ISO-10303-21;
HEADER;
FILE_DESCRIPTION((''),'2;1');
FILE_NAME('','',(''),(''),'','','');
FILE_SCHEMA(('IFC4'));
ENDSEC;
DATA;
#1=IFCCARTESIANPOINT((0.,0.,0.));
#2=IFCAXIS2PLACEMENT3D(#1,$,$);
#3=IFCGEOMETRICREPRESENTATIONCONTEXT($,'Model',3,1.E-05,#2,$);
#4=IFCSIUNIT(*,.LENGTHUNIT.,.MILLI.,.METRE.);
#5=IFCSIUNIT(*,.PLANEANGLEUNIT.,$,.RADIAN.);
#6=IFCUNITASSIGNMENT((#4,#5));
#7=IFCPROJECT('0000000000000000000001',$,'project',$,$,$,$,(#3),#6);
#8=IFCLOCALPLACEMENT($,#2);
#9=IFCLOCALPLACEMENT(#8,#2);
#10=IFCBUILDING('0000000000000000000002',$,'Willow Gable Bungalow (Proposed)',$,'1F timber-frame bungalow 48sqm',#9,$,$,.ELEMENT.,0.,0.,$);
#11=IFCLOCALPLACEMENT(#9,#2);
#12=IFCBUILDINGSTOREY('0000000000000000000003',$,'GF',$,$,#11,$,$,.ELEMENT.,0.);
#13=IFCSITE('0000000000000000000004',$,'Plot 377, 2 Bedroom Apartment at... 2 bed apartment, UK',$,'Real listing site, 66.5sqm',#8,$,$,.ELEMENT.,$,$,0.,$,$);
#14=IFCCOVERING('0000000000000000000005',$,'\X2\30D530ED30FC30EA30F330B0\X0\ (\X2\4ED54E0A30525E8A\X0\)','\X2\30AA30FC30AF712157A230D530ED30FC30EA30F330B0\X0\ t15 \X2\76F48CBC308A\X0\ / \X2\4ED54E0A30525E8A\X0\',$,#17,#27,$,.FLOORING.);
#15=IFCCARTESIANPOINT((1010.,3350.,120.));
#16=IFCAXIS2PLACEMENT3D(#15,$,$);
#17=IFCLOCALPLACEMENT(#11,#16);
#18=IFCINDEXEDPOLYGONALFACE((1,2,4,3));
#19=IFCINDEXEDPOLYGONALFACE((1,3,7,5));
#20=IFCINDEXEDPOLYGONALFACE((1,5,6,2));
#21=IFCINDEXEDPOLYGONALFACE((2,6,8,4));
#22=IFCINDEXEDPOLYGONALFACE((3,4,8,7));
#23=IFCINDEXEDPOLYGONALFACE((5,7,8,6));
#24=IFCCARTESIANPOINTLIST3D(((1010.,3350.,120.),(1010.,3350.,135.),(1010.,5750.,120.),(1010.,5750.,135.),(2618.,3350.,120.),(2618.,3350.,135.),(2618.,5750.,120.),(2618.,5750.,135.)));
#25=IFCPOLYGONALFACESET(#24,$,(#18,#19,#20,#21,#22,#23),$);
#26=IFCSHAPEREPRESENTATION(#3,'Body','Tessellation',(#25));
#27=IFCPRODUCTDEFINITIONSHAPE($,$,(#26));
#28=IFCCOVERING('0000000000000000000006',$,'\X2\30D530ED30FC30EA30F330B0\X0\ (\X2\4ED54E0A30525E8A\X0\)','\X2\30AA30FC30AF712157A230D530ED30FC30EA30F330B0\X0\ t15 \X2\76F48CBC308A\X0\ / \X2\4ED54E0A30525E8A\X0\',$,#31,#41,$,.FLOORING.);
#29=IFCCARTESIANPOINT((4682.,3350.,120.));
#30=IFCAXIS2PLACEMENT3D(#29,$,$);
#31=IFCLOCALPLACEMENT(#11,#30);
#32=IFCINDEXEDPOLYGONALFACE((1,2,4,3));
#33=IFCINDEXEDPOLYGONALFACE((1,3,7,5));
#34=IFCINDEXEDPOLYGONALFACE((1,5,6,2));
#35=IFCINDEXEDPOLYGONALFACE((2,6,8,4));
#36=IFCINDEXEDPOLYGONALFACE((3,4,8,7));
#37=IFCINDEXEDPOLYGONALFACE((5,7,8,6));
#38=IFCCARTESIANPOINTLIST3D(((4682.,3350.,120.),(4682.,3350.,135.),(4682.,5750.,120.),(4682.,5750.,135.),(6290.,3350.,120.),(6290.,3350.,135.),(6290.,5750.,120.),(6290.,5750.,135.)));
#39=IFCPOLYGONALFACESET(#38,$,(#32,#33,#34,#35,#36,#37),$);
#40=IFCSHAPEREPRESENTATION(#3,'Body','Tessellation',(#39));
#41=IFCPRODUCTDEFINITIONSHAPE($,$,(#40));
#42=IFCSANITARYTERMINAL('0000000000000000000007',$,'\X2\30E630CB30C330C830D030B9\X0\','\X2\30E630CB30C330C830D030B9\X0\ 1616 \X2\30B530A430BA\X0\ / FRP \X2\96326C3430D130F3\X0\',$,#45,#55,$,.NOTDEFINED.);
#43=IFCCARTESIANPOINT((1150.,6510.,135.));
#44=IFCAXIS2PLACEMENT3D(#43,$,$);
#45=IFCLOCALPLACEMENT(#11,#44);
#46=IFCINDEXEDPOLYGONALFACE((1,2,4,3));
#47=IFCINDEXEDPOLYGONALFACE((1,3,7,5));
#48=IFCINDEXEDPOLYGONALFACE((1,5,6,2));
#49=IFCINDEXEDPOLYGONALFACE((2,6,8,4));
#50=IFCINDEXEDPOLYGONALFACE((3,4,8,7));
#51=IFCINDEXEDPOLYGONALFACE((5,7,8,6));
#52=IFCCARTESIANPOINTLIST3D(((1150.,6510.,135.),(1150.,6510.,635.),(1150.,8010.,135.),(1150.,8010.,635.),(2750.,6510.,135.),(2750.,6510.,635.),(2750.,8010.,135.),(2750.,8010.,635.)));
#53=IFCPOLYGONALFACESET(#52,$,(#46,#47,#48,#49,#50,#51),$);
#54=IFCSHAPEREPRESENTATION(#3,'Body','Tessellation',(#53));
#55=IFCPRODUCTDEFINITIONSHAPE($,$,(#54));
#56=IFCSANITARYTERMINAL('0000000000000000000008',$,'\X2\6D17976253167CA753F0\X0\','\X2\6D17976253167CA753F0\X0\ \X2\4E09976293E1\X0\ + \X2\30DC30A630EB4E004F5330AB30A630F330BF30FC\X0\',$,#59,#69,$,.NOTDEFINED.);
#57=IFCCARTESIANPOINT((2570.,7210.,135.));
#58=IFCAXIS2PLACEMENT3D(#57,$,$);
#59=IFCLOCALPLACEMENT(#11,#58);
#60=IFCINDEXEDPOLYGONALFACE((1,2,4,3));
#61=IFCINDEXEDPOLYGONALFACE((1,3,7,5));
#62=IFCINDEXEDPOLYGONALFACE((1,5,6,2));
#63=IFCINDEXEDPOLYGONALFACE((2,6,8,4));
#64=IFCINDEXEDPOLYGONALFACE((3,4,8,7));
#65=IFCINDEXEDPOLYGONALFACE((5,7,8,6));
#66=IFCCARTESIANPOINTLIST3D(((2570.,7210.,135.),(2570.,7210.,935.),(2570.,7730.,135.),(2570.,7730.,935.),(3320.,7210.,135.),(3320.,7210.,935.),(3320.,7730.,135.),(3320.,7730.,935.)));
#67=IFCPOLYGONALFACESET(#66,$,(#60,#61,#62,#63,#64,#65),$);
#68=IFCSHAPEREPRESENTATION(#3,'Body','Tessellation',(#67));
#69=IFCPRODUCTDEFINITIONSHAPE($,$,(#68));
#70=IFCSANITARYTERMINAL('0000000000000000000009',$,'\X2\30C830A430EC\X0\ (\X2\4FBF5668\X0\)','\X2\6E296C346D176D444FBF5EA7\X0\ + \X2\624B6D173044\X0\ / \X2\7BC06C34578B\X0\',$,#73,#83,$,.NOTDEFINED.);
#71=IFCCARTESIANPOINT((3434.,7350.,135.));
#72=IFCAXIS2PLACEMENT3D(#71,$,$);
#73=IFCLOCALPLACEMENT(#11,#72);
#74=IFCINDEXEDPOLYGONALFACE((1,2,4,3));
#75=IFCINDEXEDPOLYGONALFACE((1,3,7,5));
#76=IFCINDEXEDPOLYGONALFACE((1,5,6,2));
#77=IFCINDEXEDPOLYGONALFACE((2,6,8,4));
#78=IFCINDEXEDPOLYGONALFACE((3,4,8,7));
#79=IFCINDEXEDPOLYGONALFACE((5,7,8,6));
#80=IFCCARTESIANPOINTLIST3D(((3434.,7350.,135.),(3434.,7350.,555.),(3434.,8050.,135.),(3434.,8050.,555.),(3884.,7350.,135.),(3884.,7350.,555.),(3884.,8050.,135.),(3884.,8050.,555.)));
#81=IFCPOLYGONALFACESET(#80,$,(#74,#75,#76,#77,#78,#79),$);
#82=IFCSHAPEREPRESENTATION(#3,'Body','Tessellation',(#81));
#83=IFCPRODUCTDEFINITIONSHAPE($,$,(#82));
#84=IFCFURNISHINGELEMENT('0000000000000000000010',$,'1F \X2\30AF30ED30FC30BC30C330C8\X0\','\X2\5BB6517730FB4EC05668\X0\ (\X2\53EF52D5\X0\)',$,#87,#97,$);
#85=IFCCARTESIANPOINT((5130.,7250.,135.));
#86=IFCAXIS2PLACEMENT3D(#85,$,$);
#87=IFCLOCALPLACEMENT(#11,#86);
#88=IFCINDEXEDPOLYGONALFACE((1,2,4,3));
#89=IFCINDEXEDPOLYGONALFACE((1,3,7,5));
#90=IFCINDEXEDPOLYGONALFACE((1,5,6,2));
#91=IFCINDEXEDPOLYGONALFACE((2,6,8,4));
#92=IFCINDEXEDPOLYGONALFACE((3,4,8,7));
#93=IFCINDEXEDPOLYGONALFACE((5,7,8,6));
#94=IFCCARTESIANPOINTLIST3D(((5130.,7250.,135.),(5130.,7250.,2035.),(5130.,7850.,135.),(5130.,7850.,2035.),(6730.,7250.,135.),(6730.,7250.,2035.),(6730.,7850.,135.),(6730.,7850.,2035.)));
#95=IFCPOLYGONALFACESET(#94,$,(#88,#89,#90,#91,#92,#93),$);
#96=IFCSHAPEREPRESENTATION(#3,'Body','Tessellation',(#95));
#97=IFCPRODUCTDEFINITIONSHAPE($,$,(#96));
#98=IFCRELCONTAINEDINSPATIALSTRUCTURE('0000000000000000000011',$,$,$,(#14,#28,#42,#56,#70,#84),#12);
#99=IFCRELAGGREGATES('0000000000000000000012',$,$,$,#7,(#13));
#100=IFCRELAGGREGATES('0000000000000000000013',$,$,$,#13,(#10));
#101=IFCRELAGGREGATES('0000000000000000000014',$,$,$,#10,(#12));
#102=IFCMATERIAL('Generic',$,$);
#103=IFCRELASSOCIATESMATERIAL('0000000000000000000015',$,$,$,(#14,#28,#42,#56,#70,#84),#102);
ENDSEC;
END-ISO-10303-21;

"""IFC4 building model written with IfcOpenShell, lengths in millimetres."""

from ifc_helpers import new_model, si_unit, frame, frame_2d, origin, place, context, project, spatial, rectangle, extrude, material, element, save


model = new_model("IFC4")

# Units and contexts
model_context = context("Model", 3, precision=1e-05, world=origin())
ifc_project = project(units=[si_unit("LENGTHUNIT", "METRE", prefix="MILLI"), si_unit("PLANEANGLEUNIT", "RADIAN")], contexts=[model_context])

# Site, building, storey
site_placement = place(None, origin())
site = spatial("IfcSite", under=ifc_project, at=site_placement, Name="Plot 377, 2 Bedroom Apartment at... 2 bed apartment, UK", ObjectType="Real listing site, 66.5sqm", CompositionType="ELEMENT", RefElevation=0.0)
building_placement = place(site_placement, origin())
building = spatial("IfcBuilding", under=site, at=building_placement, Name="Willow Gable Bungalow (Proposed)", ObjectType="1F timber-frame bungalow 48sqm", CompositionType="ELEMENT", ElevationOfRefHeight=0.0, ElevationOfTerrain=0.0)
storey_placement = place(building_placement, origin())
storey = spatial("IfcBuildingStorey", under=building, at=storey_placement, Name="GF", CompositionType="ELEMENT", Elevation=0.0)

# Coverings
ifc_material_1 = material(Name="Generic")
covering_1_placement = place(storey_placement, frame((1010.0, 3350.0, 120.0)))
element("IfcCovering", 1, at=covering_1_placement, inside=storey, material=ifc_material_1, Name="フローリング (仕上げ床)", Description="オーク無垢フローリング t15 直貼り / 仕上げ床", PredefinedType="FLOORING", context=model_context, shape_type="SweptSolid", body=[
    extrude(rectangle(XDim=1608.0, YDim=2400.0, at=frame_2d((804.0, 1200.0))), frame((1010.0, 3350.0, 120.0)), (0.0, 0.0, 1.0), 15.0),
])
covering_2_placement = place(storey_placement, frame((4682.0, 3350.0, 120.0)))
element("IfcCovering", 2, at=covering_2_placement, inside=storey, material=ifc_material_1, Name="フローリング (仕上げ床)", Description="オーク無垢フローリング t15 直貼り / 仕上げ床", PredefinedType="FLOORING", context=model_context, shape_type="SweptSolid", body=[
    extrude(rectangle(XDim=1608.0, YDim=2400.0, at=frame_2d((804.0, 1200.0))), frame((4682.0, 3350.0, 120.0)), (0.0, 0.0, 1.0), 15.0),
])

# Sanitary terminals
sanitary_terminal_1_placement = place(storey_placement, frame((1150.0, 6510.0, 135.0)))
element("IfcSanitaryTerminal", 3, at=sanitary_terminal_1_placement, inside=storey, material=ifc_material_1, Name="ユニットバス", Description="ユニットバス 1616 サイズ / FRP 防水パン", PredefinedType="NOTDEFINED", context=model_context, shape_type="SweptSolid", body=[
    extrude(rectangle(XDim=1600.0, YDim=1500.0, at=frame_2d((800.0, 750.0))), frame((1150.0, 6510.0, 135.0)), (0.0, 0.0, 1.0), 500.0),
])
sanitary_terminal_2_placement = place(storey_placement, frame((2570.0, 7210.0, 135.0)))
element("IfcSanitaryTerminal", 4, at=sanitary_terminal_2_placement, inside=storey, material=ifc_material_1, Name="洗面化粧台", Description="洗面化粧台 三面鏡 + ボウル一体カウンター", PredefinedType="NOTDEFINED", context=model_context, shape_type="SweptSolid", body=[
    extrude(rectangle(XDim=750.0, YDim=520.0, at=frame_2d((375.0, 260.0))), frame((2570.0, 7210.0, 135.0)), (0.0, 0.0, 1.0), 800.0),
])
sanitary_terminal_3_placement = place(storey_placement, frame((3434.0, 7350.0, 135.0)))
element("IfcSanitaryTerminal", 5, at=sanitary_terminal_3_placement, inside=storey, material=ifc_material_1, Name="トイレ (便器)", Description="温水洗浄便座 + 手洗い / 節水型", PredefinedType="NOTDEFINED", context=model_context, shape_type="SweptSolid", body=[
    extrude(rectangle(XDim=450.0, YDim=700.0, at=frame_2d((225.0, 350.0))), frame((3434.0, 7350.0, 135.0)), (0.0, 0.0, 1.0), 420.0),
])

# Furnishing element
furnishing_placement = place(storey_placement, frame((5130.0, 7250.0, 135.0)))
element("IfcFurnishingElement", 6, at=furnishing_placement, inside=storey, material=ifc_material_1, Name="1F クローゼット", Description="家具・什器 (可動)", context=model_context, shape_type="SweptSolid", body=[
    extrude(rectangle(XDim=1600.0, YDim=600.0, at=frame_2d((800.0, 300.0))), frame((5130.0, 7250.0, 135.0)), (0.0, 0.0, 1.0), 1900.0),
])

save(model, "model.ifc")
